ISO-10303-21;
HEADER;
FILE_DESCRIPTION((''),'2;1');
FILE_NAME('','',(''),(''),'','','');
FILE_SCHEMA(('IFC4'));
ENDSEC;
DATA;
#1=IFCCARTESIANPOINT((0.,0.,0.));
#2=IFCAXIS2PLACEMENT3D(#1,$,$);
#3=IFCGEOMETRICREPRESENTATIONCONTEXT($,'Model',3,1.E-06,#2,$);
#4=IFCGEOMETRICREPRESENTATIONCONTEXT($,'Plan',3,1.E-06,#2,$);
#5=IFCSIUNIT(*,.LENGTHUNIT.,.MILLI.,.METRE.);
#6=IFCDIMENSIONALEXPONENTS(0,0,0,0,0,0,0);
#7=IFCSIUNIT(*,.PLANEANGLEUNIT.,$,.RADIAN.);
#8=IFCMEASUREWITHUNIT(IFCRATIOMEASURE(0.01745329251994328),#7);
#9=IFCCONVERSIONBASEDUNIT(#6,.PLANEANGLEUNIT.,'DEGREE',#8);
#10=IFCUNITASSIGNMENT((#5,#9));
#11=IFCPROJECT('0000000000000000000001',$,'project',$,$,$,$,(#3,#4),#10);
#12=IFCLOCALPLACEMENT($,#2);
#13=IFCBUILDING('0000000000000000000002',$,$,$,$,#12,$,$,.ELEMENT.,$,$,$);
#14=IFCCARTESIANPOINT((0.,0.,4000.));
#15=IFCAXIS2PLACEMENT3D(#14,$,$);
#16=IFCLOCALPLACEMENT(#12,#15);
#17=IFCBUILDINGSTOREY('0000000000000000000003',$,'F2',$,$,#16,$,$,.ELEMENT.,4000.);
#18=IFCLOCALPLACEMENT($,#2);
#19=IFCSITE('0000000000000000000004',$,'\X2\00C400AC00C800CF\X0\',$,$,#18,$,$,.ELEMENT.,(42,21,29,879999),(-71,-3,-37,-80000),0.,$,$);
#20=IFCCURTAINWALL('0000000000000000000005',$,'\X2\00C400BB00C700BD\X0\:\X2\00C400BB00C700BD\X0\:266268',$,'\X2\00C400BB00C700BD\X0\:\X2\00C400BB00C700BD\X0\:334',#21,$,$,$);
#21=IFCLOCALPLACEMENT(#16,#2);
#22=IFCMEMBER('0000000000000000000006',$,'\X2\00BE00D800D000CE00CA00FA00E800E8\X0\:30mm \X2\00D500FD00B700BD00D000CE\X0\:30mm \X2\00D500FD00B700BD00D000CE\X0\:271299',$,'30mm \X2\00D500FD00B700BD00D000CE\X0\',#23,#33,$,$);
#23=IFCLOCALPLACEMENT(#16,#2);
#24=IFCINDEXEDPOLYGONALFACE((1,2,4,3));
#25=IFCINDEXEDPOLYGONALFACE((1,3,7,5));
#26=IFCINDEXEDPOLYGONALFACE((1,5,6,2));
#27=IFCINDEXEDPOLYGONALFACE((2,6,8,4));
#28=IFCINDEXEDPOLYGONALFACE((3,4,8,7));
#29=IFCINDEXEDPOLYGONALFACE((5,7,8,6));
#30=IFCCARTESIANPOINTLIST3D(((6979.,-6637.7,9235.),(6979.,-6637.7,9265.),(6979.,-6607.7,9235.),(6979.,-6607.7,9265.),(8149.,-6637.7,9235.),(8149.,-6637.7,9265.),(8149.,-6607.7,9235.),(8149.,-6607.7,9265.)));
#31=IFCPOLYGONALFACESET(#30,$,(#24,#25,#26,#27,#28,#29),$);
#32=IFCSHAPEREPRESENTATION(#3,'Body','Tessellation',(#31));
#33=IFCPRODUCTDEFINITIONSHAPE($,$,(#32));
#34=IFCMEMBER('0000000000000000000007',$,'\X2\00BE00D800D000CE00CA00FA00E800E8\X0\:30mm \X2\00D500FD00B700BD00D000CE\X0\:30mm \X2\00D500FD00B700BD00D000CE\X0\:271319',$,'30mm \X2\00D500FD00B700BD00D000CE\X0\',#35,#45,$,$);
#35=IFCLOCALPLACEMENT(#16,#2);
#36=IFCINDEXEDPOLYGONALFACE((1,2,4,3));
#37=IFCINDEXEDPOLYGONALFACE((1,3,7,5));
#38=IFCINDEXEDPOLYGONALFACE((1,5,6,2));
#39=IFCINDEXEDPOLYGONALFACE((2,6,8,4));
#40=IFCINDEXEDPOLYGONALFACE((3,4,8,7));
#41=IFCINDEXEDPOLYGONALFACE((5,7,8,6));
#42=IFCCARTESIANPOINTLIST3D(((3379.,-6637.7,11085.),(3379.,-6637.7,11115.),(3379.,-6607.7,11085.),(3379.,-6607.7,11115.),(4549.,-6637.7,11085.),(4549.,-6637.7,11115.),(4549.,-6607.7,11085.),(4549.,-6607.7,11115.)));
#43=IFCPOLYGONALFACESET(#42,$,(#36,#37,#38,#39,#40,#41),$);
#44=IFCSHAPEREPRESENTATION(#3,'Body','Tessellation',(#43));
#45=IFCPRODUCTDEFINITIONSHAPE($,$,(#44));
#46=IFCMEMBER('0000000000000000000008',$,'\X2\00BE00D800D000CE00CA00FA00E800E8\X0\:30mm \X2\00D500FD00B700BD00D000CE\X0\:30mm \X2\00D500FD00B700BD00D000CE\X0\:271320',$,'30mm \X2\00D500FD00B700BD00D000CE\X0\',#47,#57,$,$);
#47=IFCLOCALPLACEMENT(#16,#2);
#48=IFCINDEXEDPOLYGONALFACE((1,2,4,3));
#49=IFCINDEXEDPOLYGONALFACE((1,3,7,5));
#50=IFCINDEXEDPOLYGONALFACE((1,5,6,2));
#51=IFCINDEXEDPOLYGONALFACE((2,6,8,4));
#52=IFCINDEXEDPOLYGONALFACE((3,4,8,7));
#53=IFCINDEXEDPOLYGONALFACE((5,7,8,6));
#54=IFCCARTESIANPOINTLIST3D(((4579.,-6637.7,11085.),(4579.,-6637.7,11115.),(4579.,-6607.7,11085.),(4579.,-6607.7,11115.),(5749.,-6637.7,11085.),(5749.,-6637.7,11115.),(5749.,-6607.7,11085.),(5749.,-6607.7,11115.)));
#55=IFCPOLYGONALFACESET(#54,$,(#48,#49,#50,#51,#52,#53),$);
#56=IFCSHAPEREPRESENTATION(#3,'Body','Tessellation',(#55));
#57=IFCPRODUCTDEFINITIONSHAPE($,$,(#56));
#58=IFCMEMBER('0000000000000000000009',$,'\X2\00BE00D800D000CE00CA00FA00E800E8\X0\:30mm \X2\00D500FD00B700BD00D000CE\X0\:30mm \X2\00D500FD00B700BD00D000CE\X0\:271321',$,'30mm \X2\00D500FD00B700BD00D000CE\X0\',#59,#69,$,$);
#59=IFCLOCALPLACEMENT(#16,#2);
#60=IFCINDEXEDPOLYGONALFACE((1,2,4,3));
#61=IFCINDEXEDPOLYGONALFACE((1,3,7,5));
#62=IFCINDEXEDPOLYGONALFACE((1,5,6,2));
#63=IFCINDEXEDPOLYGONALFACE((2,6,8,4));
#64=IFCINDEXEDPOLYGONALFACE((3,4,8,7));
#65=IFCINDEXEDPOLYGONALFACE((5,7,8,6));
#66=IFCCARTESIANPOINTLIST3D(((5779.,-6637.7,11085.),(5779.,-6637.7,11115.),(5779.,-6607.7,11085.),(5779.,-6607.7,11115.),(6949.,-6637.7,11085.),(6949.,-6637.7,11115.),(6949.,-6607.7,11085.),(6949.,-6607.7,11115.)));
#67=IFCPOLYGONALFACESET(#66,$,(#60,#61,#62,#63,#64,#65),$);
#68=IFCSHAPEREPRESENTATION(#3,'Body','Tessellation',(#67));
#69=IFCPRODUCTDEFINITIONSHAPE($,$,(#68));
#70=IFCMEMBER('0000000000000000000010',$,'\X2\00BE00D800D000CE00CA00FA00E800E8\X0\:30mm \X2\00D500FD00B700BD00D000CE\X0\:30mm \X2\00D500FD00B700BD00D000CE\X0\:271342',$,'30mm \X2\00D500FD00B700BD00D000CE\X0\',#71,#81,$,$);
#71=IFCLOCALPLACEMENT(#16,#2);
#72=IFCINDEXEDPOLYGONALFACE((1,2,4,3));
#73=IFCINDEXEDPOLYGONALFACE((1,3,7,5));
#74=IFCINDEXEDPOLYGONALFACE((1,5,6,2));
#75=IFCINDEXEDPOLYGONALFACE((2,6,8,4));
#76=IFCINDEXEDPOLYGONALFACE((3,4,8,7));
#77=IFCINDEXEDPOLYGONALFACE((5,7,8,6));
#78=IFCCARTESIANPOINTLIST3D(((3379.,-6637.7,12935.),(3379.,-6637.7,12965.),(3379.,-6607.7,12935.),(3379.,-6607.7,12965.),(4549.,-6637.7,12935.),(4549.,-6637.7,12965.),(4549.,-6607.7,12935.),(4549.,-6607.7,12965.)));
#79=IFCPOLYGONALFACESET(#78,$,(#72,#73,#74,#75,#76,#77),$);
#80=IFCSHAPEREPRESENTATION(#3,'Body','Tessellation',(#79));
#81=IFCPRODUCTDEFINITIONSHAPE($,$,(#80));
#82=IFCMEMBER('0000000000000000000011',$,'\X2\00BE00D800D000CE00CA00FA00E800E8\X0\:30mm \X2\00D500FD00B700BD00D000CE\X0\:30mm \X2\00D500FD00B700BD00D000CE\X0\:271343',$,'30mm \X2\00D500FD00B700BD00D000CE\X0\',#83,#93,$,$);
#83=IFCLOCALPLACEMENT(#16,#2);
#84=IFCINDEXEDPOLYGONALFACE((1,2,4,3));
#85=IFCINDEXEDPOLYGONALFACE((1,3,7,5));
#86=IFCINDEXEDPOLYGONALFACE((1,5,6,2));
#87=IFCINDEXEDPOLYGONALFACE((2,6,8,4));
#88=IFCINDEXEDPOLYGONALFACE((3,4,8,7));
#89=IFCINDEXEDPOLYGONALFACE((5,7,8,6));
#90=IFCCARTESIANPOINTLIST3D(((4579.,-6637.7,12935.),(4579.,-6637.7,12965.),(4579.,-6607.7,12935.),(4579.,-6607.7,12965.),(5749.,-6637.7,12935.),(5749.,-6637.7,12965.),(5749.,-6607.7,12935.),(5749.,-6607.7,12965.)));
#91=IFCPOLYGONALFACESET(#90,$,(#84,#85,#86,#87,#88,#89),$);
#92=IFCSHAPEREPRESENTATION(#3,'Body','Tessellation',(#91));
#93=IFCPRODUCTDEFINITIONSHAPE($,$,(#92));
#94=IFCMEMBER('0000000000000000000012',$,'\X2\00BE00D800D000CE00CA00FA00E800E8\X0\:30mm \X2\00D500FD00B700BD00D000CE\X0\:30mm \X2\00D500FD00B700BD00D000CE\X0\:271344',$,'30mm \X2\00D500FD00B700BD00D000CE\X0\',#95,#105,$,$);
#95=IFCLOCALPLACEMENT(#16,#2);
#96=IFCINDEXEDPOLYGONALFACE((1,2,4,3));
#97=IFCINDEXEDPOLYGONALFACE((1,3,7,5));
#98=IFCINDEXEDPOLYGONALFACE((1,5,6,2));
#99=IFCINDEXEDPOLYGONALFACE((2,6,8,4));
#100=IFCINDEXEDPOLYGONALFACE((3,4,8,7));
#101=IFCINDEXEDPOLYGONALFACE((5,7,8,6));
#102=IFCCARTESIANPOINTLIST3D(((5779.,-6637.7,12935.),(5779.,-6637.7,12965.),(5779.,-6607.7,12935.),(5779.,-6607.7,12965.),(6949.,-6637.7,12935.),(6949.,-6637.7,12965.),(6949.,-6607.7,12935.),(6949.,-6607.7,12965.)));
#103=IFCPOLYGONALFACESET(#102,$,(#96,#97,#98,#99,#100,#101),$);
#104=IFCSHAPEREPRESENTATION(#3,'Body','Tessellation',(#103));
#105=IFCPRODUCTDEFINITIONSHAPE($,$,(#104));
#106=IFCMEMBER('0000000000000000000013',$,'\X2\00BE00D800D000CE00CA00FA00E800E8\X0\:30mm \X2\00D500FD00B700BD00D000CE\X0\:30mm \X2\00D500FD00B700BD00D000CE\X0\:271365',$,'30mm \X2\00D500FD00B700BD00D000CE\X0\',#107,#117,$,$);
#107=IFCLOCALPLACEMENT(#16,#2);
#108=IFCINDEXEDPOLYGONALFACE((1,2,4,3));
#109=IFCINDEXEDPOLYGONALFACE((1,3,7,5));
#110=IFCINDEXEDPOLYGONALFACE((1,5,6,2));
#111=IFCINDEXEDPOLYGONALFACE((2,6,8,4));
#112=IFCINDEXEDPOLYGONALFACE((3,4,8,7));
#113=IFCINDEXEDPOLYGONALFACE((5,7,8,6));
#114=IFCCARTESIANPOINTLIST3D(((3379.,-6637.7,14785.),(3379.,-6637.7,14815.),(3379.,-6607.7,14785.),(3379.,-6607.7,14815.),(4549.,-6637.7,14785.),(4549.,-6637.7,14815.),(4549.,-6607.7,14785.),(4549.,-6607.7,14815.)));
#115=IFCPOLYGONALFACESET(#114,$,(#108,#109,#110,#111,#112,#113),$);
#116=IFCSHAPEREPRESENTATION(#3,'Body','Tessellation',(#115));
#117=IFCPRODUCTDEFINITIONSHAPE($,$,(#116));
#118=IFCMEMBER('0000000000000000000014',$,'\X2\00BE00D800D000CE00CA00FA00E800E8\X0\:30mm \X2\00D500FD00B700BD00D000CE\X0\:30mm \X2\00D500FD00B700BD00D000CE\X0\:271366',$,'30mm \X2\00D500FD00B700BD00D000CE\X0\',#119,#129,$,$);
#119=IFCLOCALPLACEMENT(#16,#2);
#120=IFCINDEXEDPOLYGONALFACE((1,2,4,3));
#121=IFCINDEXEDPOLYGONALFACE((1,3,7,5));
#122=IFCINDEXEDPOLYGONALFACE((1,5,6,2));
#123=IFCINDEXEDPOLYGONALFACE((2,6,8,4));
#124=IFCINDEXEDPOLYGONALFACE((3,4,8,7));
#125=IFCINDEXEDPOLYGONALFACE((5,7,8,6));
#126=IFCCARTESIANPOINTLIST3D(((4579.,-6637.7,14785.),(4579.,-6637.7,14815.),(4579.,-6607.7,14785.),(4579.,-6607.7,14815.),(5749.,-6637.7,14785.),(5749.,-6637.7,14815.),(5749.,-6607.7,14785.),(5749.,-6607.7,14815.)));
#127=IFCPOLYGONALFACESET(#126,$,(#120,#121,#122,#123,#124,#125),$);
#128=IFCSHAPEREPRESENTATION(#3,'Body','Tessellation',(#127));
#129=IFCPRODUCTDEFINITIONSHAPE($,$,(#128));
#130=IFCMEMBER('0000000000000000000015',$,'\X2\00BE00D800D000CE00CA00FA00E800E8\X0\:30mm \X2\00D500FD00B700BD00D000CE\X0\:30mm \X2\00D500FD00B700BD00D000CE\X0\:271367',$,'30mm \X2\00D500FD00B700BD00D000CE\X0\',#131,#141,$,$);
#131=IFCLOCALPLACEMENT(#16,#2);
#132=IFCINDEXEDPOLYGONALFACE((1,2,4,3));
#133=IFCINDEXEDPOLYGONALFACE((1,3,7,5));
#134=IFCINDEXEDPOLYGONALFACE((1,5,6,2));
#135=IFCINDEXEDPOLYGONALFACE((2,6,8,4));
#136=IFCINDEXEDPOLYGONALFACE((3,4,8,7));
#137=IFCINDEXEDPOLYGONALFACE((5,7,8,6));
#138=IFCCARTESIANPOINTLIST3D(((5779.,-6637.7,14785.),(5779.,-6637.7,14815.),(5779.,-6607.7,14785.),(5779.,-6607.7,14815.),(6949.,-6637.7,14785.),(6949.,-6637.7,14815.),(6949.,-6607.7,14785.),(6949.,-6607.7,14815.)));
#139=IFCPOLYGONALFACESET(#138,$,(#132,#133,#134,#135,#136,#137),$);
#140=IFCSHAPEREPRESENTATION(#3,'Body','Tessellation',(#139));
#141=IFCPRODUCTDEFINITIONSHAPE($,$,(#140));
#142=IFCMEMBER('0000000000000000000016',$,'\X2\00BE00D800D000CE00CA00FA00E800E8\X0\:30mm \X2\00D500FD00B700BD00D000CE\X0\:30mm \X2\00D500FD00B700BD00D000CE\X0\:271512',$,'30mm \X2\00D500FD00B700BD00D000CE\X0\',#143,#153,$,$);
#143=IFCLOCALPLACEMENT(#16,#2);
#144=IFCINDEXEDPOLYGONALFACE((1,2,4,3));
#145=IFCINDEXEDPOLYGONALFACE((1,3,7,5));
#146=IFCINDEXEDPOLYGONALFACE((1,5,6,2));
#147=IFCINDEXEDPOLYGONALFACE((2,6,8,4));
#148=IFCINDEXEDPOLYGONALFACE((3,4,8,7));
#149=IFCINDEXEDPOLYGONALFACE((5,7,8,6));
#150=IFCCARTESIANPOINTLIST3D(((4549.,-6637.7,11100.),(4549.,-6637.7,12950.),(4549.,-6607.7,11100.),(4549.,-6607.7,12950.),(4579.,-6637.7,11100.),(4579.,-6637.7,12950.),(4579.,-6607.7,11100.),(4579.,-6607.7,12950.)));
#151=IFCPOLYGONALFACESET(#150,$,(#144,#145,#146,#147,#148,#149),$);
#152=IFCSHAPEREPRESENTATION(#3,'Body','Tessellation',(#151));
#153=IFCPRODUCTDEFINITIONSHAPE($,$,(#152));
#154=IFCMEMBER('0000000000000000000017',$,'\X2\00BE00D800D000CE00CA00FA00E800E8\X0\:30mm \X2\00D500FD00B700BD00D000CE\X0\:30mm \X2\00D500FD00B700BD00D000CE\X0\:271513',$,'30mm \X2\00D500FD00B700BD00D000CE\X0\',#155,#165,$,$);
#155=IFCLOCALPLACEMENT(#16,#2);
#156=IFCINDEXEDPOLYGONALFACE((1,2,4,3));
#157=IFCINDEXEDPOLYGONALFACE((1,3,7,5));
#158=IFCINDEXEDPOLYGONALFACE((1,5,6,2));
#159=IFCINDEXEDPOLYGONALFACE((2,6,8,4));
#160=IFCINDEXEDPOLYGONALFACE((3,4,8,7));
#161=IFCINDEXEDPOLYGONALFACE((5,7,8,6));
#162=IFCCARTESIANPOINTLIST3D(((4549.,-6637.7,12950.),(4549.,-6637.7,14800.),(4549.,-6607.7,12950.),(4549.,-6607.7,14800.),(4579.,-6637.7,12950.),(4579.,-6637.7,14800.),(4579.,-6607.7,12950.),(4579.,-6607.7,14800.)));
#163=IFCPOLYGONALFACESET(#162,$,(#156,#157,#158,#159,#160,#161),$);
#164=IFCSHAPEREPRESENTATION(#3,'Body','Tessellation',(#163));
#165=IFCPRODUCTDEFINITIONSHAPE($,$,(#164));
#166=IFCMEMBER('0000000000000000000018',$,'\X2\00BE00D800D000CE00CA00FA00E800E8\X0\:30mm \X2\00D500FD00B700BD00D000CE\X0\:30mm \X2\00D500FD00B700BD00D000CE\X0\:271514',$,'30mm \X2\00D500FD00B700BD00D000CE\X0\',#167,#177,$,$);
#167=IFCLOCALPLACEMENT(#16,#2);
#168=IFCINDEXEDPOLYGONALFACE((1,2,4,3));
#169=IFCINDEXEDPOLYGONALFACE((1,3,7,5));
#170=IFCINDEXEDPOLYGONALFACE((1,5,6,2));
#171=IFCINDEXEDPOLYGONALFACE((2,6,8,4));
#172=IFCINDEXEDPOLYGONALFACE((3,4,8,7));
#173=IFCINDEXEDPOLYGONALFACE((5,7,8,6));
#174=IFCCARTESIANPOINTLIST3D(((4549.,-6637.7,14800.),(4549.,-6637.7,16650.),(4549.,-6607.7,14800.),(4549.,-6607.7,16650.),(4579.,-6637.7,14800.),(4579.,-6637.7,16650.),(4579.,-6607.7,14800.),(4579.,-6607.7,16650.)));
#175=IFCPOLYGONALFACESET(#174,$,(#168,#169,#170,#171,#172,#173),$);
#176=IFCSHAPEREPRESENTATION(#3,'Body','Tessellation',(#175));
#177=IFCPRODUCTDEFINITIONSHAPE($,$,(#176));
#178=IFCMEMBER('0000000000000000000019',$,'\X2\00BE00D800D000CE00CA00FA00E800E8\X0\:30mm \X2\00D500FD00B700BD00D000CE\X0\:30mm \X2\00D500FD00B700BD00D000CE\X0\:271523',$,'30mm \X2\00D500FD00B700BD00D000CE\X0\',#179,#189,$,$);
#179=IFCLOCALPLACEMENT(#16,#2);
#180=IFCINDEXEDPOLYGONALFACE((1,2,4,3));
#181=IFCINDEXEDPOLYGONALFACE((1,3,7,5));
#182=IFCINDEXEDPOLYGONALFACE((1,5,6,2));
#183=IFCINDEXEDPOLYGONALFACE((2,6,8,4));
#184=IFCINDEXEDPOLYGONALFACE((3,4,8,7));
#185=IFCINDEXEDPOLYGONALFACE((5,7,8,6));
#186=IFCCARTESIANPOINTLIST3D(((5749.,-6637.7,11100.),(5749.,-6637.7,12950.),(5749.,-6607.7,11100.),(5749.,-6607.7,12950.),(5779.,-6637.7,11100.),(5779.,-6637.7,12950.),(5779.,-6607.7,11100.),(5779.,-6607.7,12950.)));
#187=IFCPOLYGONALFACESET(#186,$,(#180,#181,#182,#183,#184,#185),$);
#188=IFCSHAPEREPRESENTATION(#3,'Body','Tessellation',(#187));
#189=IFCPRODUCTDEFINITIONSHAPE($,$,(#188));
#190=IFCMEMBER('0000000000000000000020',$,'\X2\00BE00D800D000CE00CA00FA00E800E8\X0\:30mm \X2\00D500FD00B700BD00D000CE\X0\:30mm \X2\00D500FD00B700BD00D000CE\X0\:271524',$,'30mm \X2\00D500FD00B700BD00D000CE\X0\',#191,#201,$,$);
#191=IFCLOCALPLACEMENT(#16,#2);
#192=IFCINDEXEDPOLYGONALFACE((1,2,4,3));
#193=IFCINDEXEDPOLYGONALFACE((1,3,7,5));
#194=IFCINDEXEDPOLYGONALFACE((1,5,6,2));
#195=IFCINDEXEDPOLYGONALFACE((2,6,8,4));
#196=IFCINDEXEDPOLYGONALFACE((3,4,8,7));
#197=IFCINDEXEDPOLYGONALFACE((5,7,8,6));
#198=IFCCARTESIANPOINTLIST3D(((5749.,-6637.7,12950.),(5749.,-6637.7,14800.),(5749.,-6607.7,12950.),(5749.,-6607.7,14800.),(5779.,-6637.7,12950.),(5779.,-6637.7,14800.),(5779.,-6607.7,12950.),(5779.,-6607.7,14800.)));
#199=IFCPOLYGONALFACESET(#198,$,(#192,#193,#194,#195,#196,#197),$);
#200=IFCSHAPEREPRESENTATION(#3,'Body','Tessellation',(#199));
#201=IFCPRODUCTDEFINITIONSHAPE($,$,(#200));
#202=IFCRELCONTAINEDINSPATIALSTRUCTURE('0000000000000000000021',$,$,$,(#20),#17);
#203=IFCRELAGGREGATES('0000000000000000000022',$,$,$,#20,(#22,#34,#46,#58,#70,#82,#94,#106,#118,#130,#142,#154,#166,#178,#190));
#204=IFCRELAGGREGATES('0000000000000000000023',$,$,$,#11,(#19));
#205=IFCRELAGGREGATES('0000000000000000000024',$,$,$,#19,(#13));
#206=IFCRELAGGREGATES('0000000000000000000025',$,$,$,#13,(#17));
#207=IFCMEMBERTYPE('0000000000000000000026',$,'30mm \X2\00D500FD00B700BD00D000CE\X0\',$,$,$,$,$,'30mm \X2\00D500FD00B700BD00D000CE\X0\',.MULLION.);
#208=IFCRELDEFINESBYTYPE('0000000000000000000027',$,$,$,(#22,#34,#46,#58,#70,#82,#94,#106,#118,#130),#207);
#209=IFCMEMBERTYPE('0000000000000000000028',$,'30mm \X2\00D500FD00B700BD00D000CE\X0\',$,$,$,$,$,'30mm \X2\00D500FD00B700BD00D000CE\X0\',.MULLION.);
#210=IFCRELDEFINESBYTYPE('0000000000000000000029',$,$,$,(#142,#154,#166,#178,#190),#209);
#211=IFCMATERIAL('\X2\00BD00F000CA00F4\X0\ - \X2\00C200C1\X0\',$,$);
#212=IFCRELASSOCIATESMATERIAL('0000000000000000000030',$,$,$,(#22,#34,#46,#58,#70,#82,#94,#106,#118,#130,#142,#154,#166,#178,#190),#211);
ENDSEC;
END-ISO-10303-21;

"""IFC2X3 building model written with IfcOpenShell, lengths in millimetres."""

from ifc_helpers import new_model, entity, si_unit, converted_unit, frame, origin, origin_2d_with_axis, place, context, project, spatial, rectangle, extrude, source, transform, mapped, material, type_object, type_shapes, element, aggregate, save


model = new_model("IFC2X3")

# Units and contexts
model_context = context("Model", 3, precision=1e-06, world=origin())
plan_context = context("Plan", 3, precision=1e-06, world=origin())
ifc_project = project(units=[si_unit("LENGTHUNIT", "METRE", prefix="MILLI"), converted_unit("PLANEANGLEUNIT", "DEGREE", entity("IfcRatioMeasure", 0.01745329251994328), si_unit("PLANEANGLEUNIT", "RADIAN"), dimensions=[0, 0, 0, 0, 0, 0, 0])], contexts=[model_context, plan_context])

# Site, building, storey
site_placement = place(None, origin())
site = spatial("IfcSite", under=ifc_project, at=site_placement, Name="Ä¬ÈÏ", CompositionType="ELEMENT", RefLatitude=(42, 21, 29, 879999), RefLongitude=(-71, -3, -37, -80000), RefElevation=0.0)
building_placement = place(None, origin())
building = spatial("IfcBuilding", under=site, at=building_placement, CompositionType="ELEMENT")
storey_placement = place(building_placement, frame((0.0, 0.0, 4000.0)))
storey = spatial("IfcBuildingStorey", under=building, at=storey_placement, Name="F2", CompositionType="ELEMENT", Elevation=4000.0)

# Curtain wall, members
curtain_wall_placement = place(storey_placement, origin())
curtain_wall = element("IfcCurtainWall", 1, at=curtain_wall_placement, inside=storey, Name="Ä»Ç½:Ä»Ç½:266268", ObjectType="Ä»Ç½:Ä»Ç½:334")
ifc_material_1 = material(Name="½ðÊô - ÂÁ")
member_type_1 = type_object("IfcMemberType", Name="30mm Õý·½ÐÎ", ElementType="30mm Õý·½ÐÎ", PredefinedType="MULLION")
shared_shape_1 = source(origin(), model_context, "Body", "SweptSolid", [
    extrude(rectangle(XDim=30.0, YDim=30.0, at=origin_2d_with_axis()), frame((0.0, 0.0, -1170.0), z_axis=(0.0, 0.0, 1.0), x_axis=(-1.0, 0.0, 0.0)), (0.0, 0.0, 1.0), 1170.0),
])
type_shapes(member_type_1, [shared_shape_1])
placement_1 = place(building_placement, frame((0.0, 0.0, 11400.0)))
member_1_placement = place(placement_1, frame((8149.0, -6622.7, 1850.0), z_axis=(1.0, 0.0, 0.0), x_axis=(0.0, 0.0, 1.0)))
member_1 = element("IfcMember", 2, at=member_1_placement, type_object=member_type_1, material=ifc_material_1, Name="¾ØÐÎÊúèè:30mm Õý·½ÐÎ:30mm Õý·½ÐÎ:271299", ObjectType="30mm Õý·½ÐÎ", context=model_context, shape_type="MappedRepresentation", body=[
    mapped(shared_shape_1, transform((0.0, 0.0, 0.0), scale=1.0)),
])
placement_2 = place(building_placement, frame((0.0, 0.0, 15100.0)))
member_2_placement = place(placement_2, frame((4549.0, -6622.7, 0.0), z_axis=(1.0, 0.0, 0.0), x_axis=(0.0, 0.0, 1.0)))
member_2 = element("IfcMember", 3, at=member_2_placement, type_object=member_type_1, material=ifc_material_1, Name="¾ØÐÎÊúèè:30mm Õý·½ÐÎ:30mm Õý·½ÐÎ:271319", ObjectType="30mm Õý·½ÐÎ", context=model_context, shape_type="MappedRepresentation", body=[
    mapped(shared_shape_1, transform((0.0, 0.0, 0.0), scale=1.0)),
])
member_3_placement = place(placement_2, frame((5749.0, -6622.7, 0.0), z_axis=(1.0, 0.0, 0.0), x_axis=(0.0, 0.0, 1.0)))
member_3 = element("IfcMember", 4, at=member_3_placement, type_object=member_type_1, material=ifc_material_1, Name="¾ØÐÎÊúèè:30mm Õý·½ÐÎ:30mm Õý·½ÐÎ:271320", ObjectType="30mm Õý·½ÐÎ", context=model_context, shape_type="MappedRepresentation", body=[
    mapped(shared_shape_1, transform((0.0, 0.0, 0.0), scale=1.0)),
])
member_4_placement = place(placement_2, frame((6949.0, -6622.7, 0.0), z_axis=(1.0, 0.0, 0.0), x_axis=(0.0, 0.0, 1.0)))
member_4 = element("IfcMember", 5, at=member_4_placement, type_object=member_type_1, material=ifc_material_1, Name="¾ØÐÎÊúèè:30mm Õý·½ÐÎ:30mm Õý·½ÐÎ:271321", ObjectType="30mm Õý·½ÐÎ", context=model_context, shape_type="MappedRepresentation", body=[
    mapped(shared_shape_1, transform((0.0, 0.0, 0.0), scale=1.0)),
])
member_5_placement = place(placement_2, frame((4549.0, -6622.7, 1850.0), z_axis=(1.0, 0.0, 0.0), x_axis=(0.0, 0.0, 1.0)))
member_5 = element("IfcMember", 6, at=member_5_placement, type_object=member_type_1, material=ifc_material_1, Name="¾ØÐÎÊúèè:30mm Õý·½ÐÎ:30mm Õý·½ÐÎ:271342", ObjectType="30mm Õý·½ÐÎ", context=model_context, shape_type="MappedRepresentation", body=[
    mapped(shared_shape_1, transform((0.0, 0.0, 0.0), scale=1.0)),
])
member_6_placement = place(placement_2, frame((5749.0, -6622.7, 1850.0), z_axis=(1.0, 0.0, 0.0), x_axis=(0.0, 0.0, 1.0)))
member_6 = element("IfcMember", 7, at=member_6_placement, type_object=member_type_1, material=ifc_material_1, Name="¾ØÐÎÊúèè:30mm Õý·½ÐÎ:30mm Õý·½ÐÎ:271343", ObjectType="30mm Õý·½ÐÎ", context=model_context, shape_type="MappedRepresentation", body=[
    mapped(shared_shape_1, transform((0.0, 0.0, 0.0), scale=1.0)),
])
member_7_placement = place(placement_2, frame((6949.0, -6622.7, 1850.0), z_axis=(1.0, 0.0, 0.0), x_axis=(0.0, 0.0, 1.0)))
member_7 = element("IfcMember", 8, at=member_7_placement, type_object=member_type_1, material=ifc_material_1, Name="¾ØÐÎÊúèè:30mm Õý·½ÐÎ:30mm Õý·½ÐÎ:271344", ObjectType="30mm Õý·½ÐÎ", context=model_context, shape_type="MappedRepresentation", body=[
    mapped(shared_shape_1, transform((0.0, 0.0, 0.0), scale=1.0)),
])
placement_3 = place(building_placement, frame((0.0, 0.0, 18800.0)))
member_8_placement = place(placement_3, frame((4549.0, -6622.7, 0.0), z_axis=(1.0, 0.0, 0.0), x_axis=(0.0, 0.0, 1.0)))
member_8 = element("IfcMember", 9, at=member_8_placement, type_object=member_type_1, material=ifc_material_1, Name="¾ØÐÎÊúèè:30mm Õý·½ÐÎ:30mm Õý·½ÐÎ:271365", ObjectType="30mm Õý·½ÐÎ", context=model_context, shape_type="MappedRepresentation", body=[
    mapped(shared_shape_1, transform((0.0, 0.0, 0.0), scale=1.0)),
])
member_9_placement = place(placement_3, frame((5749.0, -6622.7, 0.0), z_axis=(1.0, 0.0, 0.0), x_axis=(0.0, 0.0, 1.0)))
member_9 = element("IfcMember", 10, at=member_9_placement, type_object=member_type_1, material=ifc_material_1, Name="¾ØÐÎÊúèè:30mm Õý·½ÐÎ:30mm Õý·½ÐÎ:271366", ObjectType="30mm Õý·½ÐÎ", context=model_context, shape_type="MappedRepresentation", body=[
    mapped(shared_shape_1, transform((0.0, 0.0, 0.0), scale=1.0)),
])
member_10_placement = place(placement_3, frame((6949.0, -6622.7, 0.0), z_axis=(1.0, 0.0, 0.0), x_axis=(0.0, 0.0, 1.0)))
member_10 = element("IfcMember", 11, at=member_10_placement, type_object=member_type_1, material=ifc_material_1, Name="¾ØÐÎÊúèè:30mm Õý·½ÐÎ:30mm Õý·½ÐÎ:271367", ObjectType="30mm Õý·½ÐÎ", context=model_context, shape_type="MappedRepresentation", body=[
    mapped(shared_shape_1, transform((0.0, 0.0, 0.0), scale=1.0)),
])
member_type_2 = type_object("IfcMemberType", Name="30mm Õý·½ÐÎ", ElementType="30mm Õý·½ÐÎ", PredefinedType="MULLION")
shared_shape_2 = source(origin(), model_context, "Body", "SweptSolid", [
    extrude(rectangle(XDim=30.0, YDim=30.0, at=origin_2d_with_axis()), frame((0.0, 0.0, -1850.0), z_axis=(0.0, 0.0, 1.0), x_axis=(-1.0, 0.0, 0.0)), (0.0, 0.0, 1.0), 1850.0),
])
type_shapes(member_type_2, [shared_shape_2])
member_11_placement = place(placement_2, frame((4564.0, -6622.7, 0.0), z_axis=(0.0, 0.0, -1.0), x_axis=(1.0, 0.0, 0.0)))
member_11 = element("IfcMember", 12, at=member_11_placement, type_object=member_type_2, material=ifc_material_1, Name="¾ØÐÎÊúèè:30mm Õý·½ÐÎ:30mm Õý·½ÐÎ:271512", ObjectType="30mm Õý·½ÐÎ", context=model_context, shape_type="MappedRepresentation", body=[
    mapped(shared_shape_2, transform((0.0, 0.0, 0.0), scale=1.0)),
])
member_12_placement = place(placement_2, frame((4564.0, -6622.7, 1850.0), z_axis=(0.0, 0.0, -1.0), x_axis=(1.0, 0.0, 0.0)))
member_12 = element("IfcMember", 13, at=member_12_placement, type_object=member_type_2, material=ifc_material_1, Name="¾ØÐÎÊúèè:30mm Õý·½ÐÎ:30mm Õý·½ÐÎ:271513", ObjectType="30mm Õý·½ÐÎ", context=model_context, shape_type="MappedRepresentation", body=[
    mapped(shared_shape_2, transform((0.0, 0.0, 0.0), scale=1.0)),
])
member_13_placement = place(placement_3, frame((4564.0, -6622.7, 0.0), z_axis=(0.0, 0.0, -1.0), x_axis=(1.0, 0.0, 0.0)))
member_13 = element("IfcMember", 14, at=member_13_placement, type_object=member_type_2, material=ifc_material_1, Name="¾ØÐÎÊúèè:30mm Õý·½ÐÎ:30mm Õý·½ÐÎ:271514", ObjectType="30mm Õý·½ÐÎ", context=model_context, shape_type="MappedRepresentation", body=[
    mapped(shared_shape_2, transform((0.0, 0.0, 0.0), scale=1.0)),
])
member_14_placement = place(placement_2, frame((5764.0, -6622.7, 0.0), z_axis=(0.0, 0.0, -1.0), x_axis=(1.0, 0.0, 0.0)))
member_14 = element("IfcMember", 15, at=member_14_placement, type_object=member_type_2, material=ifc_material_1, Name="¾ØÐÎÊúèè:30mm Õý·½ÐÎ:30mm Õý·½ÐÎ:271523", ObjectType="30mm Õý·½ÐÎ", context=model_context, shape_type="MappedRepresentation", body=[
    mapped(shared_shape_2, transform((0.0, 0.0, 0.0), scale=1.0)),
])
member_15_placement = place(placement_2, frame((5764.0, -6622.7, 1850.0), z_axis=(0.0, 0.0, -1.0), x_axis=(1.0, 0.0, 0.0)))
member_15 = element("IfcMember", 16, at=member_15_placement, type_object=member_type_2, material=ifc_material_1, Name="¾ØÐÎÊúèè:30mm Õý·½ÐÎ:30mm Õý·½ÐÎ:271524", ObjectType="30mm Õý·½ÐÎ", context=model_context, shape_type="MappedRepresentation", body=[
    mapped(shared_shape_2, transform((0.0, 0.0, 0.0), scale=1.0)),
])
aggregate(curtain_wall, [member_1, member_2, member_3, member_4, member_5, member_6, member_7, member_8, member_9, member_10, member_11, member_12, member_13, member_14, member_15])

save(model, "model.ifc")
